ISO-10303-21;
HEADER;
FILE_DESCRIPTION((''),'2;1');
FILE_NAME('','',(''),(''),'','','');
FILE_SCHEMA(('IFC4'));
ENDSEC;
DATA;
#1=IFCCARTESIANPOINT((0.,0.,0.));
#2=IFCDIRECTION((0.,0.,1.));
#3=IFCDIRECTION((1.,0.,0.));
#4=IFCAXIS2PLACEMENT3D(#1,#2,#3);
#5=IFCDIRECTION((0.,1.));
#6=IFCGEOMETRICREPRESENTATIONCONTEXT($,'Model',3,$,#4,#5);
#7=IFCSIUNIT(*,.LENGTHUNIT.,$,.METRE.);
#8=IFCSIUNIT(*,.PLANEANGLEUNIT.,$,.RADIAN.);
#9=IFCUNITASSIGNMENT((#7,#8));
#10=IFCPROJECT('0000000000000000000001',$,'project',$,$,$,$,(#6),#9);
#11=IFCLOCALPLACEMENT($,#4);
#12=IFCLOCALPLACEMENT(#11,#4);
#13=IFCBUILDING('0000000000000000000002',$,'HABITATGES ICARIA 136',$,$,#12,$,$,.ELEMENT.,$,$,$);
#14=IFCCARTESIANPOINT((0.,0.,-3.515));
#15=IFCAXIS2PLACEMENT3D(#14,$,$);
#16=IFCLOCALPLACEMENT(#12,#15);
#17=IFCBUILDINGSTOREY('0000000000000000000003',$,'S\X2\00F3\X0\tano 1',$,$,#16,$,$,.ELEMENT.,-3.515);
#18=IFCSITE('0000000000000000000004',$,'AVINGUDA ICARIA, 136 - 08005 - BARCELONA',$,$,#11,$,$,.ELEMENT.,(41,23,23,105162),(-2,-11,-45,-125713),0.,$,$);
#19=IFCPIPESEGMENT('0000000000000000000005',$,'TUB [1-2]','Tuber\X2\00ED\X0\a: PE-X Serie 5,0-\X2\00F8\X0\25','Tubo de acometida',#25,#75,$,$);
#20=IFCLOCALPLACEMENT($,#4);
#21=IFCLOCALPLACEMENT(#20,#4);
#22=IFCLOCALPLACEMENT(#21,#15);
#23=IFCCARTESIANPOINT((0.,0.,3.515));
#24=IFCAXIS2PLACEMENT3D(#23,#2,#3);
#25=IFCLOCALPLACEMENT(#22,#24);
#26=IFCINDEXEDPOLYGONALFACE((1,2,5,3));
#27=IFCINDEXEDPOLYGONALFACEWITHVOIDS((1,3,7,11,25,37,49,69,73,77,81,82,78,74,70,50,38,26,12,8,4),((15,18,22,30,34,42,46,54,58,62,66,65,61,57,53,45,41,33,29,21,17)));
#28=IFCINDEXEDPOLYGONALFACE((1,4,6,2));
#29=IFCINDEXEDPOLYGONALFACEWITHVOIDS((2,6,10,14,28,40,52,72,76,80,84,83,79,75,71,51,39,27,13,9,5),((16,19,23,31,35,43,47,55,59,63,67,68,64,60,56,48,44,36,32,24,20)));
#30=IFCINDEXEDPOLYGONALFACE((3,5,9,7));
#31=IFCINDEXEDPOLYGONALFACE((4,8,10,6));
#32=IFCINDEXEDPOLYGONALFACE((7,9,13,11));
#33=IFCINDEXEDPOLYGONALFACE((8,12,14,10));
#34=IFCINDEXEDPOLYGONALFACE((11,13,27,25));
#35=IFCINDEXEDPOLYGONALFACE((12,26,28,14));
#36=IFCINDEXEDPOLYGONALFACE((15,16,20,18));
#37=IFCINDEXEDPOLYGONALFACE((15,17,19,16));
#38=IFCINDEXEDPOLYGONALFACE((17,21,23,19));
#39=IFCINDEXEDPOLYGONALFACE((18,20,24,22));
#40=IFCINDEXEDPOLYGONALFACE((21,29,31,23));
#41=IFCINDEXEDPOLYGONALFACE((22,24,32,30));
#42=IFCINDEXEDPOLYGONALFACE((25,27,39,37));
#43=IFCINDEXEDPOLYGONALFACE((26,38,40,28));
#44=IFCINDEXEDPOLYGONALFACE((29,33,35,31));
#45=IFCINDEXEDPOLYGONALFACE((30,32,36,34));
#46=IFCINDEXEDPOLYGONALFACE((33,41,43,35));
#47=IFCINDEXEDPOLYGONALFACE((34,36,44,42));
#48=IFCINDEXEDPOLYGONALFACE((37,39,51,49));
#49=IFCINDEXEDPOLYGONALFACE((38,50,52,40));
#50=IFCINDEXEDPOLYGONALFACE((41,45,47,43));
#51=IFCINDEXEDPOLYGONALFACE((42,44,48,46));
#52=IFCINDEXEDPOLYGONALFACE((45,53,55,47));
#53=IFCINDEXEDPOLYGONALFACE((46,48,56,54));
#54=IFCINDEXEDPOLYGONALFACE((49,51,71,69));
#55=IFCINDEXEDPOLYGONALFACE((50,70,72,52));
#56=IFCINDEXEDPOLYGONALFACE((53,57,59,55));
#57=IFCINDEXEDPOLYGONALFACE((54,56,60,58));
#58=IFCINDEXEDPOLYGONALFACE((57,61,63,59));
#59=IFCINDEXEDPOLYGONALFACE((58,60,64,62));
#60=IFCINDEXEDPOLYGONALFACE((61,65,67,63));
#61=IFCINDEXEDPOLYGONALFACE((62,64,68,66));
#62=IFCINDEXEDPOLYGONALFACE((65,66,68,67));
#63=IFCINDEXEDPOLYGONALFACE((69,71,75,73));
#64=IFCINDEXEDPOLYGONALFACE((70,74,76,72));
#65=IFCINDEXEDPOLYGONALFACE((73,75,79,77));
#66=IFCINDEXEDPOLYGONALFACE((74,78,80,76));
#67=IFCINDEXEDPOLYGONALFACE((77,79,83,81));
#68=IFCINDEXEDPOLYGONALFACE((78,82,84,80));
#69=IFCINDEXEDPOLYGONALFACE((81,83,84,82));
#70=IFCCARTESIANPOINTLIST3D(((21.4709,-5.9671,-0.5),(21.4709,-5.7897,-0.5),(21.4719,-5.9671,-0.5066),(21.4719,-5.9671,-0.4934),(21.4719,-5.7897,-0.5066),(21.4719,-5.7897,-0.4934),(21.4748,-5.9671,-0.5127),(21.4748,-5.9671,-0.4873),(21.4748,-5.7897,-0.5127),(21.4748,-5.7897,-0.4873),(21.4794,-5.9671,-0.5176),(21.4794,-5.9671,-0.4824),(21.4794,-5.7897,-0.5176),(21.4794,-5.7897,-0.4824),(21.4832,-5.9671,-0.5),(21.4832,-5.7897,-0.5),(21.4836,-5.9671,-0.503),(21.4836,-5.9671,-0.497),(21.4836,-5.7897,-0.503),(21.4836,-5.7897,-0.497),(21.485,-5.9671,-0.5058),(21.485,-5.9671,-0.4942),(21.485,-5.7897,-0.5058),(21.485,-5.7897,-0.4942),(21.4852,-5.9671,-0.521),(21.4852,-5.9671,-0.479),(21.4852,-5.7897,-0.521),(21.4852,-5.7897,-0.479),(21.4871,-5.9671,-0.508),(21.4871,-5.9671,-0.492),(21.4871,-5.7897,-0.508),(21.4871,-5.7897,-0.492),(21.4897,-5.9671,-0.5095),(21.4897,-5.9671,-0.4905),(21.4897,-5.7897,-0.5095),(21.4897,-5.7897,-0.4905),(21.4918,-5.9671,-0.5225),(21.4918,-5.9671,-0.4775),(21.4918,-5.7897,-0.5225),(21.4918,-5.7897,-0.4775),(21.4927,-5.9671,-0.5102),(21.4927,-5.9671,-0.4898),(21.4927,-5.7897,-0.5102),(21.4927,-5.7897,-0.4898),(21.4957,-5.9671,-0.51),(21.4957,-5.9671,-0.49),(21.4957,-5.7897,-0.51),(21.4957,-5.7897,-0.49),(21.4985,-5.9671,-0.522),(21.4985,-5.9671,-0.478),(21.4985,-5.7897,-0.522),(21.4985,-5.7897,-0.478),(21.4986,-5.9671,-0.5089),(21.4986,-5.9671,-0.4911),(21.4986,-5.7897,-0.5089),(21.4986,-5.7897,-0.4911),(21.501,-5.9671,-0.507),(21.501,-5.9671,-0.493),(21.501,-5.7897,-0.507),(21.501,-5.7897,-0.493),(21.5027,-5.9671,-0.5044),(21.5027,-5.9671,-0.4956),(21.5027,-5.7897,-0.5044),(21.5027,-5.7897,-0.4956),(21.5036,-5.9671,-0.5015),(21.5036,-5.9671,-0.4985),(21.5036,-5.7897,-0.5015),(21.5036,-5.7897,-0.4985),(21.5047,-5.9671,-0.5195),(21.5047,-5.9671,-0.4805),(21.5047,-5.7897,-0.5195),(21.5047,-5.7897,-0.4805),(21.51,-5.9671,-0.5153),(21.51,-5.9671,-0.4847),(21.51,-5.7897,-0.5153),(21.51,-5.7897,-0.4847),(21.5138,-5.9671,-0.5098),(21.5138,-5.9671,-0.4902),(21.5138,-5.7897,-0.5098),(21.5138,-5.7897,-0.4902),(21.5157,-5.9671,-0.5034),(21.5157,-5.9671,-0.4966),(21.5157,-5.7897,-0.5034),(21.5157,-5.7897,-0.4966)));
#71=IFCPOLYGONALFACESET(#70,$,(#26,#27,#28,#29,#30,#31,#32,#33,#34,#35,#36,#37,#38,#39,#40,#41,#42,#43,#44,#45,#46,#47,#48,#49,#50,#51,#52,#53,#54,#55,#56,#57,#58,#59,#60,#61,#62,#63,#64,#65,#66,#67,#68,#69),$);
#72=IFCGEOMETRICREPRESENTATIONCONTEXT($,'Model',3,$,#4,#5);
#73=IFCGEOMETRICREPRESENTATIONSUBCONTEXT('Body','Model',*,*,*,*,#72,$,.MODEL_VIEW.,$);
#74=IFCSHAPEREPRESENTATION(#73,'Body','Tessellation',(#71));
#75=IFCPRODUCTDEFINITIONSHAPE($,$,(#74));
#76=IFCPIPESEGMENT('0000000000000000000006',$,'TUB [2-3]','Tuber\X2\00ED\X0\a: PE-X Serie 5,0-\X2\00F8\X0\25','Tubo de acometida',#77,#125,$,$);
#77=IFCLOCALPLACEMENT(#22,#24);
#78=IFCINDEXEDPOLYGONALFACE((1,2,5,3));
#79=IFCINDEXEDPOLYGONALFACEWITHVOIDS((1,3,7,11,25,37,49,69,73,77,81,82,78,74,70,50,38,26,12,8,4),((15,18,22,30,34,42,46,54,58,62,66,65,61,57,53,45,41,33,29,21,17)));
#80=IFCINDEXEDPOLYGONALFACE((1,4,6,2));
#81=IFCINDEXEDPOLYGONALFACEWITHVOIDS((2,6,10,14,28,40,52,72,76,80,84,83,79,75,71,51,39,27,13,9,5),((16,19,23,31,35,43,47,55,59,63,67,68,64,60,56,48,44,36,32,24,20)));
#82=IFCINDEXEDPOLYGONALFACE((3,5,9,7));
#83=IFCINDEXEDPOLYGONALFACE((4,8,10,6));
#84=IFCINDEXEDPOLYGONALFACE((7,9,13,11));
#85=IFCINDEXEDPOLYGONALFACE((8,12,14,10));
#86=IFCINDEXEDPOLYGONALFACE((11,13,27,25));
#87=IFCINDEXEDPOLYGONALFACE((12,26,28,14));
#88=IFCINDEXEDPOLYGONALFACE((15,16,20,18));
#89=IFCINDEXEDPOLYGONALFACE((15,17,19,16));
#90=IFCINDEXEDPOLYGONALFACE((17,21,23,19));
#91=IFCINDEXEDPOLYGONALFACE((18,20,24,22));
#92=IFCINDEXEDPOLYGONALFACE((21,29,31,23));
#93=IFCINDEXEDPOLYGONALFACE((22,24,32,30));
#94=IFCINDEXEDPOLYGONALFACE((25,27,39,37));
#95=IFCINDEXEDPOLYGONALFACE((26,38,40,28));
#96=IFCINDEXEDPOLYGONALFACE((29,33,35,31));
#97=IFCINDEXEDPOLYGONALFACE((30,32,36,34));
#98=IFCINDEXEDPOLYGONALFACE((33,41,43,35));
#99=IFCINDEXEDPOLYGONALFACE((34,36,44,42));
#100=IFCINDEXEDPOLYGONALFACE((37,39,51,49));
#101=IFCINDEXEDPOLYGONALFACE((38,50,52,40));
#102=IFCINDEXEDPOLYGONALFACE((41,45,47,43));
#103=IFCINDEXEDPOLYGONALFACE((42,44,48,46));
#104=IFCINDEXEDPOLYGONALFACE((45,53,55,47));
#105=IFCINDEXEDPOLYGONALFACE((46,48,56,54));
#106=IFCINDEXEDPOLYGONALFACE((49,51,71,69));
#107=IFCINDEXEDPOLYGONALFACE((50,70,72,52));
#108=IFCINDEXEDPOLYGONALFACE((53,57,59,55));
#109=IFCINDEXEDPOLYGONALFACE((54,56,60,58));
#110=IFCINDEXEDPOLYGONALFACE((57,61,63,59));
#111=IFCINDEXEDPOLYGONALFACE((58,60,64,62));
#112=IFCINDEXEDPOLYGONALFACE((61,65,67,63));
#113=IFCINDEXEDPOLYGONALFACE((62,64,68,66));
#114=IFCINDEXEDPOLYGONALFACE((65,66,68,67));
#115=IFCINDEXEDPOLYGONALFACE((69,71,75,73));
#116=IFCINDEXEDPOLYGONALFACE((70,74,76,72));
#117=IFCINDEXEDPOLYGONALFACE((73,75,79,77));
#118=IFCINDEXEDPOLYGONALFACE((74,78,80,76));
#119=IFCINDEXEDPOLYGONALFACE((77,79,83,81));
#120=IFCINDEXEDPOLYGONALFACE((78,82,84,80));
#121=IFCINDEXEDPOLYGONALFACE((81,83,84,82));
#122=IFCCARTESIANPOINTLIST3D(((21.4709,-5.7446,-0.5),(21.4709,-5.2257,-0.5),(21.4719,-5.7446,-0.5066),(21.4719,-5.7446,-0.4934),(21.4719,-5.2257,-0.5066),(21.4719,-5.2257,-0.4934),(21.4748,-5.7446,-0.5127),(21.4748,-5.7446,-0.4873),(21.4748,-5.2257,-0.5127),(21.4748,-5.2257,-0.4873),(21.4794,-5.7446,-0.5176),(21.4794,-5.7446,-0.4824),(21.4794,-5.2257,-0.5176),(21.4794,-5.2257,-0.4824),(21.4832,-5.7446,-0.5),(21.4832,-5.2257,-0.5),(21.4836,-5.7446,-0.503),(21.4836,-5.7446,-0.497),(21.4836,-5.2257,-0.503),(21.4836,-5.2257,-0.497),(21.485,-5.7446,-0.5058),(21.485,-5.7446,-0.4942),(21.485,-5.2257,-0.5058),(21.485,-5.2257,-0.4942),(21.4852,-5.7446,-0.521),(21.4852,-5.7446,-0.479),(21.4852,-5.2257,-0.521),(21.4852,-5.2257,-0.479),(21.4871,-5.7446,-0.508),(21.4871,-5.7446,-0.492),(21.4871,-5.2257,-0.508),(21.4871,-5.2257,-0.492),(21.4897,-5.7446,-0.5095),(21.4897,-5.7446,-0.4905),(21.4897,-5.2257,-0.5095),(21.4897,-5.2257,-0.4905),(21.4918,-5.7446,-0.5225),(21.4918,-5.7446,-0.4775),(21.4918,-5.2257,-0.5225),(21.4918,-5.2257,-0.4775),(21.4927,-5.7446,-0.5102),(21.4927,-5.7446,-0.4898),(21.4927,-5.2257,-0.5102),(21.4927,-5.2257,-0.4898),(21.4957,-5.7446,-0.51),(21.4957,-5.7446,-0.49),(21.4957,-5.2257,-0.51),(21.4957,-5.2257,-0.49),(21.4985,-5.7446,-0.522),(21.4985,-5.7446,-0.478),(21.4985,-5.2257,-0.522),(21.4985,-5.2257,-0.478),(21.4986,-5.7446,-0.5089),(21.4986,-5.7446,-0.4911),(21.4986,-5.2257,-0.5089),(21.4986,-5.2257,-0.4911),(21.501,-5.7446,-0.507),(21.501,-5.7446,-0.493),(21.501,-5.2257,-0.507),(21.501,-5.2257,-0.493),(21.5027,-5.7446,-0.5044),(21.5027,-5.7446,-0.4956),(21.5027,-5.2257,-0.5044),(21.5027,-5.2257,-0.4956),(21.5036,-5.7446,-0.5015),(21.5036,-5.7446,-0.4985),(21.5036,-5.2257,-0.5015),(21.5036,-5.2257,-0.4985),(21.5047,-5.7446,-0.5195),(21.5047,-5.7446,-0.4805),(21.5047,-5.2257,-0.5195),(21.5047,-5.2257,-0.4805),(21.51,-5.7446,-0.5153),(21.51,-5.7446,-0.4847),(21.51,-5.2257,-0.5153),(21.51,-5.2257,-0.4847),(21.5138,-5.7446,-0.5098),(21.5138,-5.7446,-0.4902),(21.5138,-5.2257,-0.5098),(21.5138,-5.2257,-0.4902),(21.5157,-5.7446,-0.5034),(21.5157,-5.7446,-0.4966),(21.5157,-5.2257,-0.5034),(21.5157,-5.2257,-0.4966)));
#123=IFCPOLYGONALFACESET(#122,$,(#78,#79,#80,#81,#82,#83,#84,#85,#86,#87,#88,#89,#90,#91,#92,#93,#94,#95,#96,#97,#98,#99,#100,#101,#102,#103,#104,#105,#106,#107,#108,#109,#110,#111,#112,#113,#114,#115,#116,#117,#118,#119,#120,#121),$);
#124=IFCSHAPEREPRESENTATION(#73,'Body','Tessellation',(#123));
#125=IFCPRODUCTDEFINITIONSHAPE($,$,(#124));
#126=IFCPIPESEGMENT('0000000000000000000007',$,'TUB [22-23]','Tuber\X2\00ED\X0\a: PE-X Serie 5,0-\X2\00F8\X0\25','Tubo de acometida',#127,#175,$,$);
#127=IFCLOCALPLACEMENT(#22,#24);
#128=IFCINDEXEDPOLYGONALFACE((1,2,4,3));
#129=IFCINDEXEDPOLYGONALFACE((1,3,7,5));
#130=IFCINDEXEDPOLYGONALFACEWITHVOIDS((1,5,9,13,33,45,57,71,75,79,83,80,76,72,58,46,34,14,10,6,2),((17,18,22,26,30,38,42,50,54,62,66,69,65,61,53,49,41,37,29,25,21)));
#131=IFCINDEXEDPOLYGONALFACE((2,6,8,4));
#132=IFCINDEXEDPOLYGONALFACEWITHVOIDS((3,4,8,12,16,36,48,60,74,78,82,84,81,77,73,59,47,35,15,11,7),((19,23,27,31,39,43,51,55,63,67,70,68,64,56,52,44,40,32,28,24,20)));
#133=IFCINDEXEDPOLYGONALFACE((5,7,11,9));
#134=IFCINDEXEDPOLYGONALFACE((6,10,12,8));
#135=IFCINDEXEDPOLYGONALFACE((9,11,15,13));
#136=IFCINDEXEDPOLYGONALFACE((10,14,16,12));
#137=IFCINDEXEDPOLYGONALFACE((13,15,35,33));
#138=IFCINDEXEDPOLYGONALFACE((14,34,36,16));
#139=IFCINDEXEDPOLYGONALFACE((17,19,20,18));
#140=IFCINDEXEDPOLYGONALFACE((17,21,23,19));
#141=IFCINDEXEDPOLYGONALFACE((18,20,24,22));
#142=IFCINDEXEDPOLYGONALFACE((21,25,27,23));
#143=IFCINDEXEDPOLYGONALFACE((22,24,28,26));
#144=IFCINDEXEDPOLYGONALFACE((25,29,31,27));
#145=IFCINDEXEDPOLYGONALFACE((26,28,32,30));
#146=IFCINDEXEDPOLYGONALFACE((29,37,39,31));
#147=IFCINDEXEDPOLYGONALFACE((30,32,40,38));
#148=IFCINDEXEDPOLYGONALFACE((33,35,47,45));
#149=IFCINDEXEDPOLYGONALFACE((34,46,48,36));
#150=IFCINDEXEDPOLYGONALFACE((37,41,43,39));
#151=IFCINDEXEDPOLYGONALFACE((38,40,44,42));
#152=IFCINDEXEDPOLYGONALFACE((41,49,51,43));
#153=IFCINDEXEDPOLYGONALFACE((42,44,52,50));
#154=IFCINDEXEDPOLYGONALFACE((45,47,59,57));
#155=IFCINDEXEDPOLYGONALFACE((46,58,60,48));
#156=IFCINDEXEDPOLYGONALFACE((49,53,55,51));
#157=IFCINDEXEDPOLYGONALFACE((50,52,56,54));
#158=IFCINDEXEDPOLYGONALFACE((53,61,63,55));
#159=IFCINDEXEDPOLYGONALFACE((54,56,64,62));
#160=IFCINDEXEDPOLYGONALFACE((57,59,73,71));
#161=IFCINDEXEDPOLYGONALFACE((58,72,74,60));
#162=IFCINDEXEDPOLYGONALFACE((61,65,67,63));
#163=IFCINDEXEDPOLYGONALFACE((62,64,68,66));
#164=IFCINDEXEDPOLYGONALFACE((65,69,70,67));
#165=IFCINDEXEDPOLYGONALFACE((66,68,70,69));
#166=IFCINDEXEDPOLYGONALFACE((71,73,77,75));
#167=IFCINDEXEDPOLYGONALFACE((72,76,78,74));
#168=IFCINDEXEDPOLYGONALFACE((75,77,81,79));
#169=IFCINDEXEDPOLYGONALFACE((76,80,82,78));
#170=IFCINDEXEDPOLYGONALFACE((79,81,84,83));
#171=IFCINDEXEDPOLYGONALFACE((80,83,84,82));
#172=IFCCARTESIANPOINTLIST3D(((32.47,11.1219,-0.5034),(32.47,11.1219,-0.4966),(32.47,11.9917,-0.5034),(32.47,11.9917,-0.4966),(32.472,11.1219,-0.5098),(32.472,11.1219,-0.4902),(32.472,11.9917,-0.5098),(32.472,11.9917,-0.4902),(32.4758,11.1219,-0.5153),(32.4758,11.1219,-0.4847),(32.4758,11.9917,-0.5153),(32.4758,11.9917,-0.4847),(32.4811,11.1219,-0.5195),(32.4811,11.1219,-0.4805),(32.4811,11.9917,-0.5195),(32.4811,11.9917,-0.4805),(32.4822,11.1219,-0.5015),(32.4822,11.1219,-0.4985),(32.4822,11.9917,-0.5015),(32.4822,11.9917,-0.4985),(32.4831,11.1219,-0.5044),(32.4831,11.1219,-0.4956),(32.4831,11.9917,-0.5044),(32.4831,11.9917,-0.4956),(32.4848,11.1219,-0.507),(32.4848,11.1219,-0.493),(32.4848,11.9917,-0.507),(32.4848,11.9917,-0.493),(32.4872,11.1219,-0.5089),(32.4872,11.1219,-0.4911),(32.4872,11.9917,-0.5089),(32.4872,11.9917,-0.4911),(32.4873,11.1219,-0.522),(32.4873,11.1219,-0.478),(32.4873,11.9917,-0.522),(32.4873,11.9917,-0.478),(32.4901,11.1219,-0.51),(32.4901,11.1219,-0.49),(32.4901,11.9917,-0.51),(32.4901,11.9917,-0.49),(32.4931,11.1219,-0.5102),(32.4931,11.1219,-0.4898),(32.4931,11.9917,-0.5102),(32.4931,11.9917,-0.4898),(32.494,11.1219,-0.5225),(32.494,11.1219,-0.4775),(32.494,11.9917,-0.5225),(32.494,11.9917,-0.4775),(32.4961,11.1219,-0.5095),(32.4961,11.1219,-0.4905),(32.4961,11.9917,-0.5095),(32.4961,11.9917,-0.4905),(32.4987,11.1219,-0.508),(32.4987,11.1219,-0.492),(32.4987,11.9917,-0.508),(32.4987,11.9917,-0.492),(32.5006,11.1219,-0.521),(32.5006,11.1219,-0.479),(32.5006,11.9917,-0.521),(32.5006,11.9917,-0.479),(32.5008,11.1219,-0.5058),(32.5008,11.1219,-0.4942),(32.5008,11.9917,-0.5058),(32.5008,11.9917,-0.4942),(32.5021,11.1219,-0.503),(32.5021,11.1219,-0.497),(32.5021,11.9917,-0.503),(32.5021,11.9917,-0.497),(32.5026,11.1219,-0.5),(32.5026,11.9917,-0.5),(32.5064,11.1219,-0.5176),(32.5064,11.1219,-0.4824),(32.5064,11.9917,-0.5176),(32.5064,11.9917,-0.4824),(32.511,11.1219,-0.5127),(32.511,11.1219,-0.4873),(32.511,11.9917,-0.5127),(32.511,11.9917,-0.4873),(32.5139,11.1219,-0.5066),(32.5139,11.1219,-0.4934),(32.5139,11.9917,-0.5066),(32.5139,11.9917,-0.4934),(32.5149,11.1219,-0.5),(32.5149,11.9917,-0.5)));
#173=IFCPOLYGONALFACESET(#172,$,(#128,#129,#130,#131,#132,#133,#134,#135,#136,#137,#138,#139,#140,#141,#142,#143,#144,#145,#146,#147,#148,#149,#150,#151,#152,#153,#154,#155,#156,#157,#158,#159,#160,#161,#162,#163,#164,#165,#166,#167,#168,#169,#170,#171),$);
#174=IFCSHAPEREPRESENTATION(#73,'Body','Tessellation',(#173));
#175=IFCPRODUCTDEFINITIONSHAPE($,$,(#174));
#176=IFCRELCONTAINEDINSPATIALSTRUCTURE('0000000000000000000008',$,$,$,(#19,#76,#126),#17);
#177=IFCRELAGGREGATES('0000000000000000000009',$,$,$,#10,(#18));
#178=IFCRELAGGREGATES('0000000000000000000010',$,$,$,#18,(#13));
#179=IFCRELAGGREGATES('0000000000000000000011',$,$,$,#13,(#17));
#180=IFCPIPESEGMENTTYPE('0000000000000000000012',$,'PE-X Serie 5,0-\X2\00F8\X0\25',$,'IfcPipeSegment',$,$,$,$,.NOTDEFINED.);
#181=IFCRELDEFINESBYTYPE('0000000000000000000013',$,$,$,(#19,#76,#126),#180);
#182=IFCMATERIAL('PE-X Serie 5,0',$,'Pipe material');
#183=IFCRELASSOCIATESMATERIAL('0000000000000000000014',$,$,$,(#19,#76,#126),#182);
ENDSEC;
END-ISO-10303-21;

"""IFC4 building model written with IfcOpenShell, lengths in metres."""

from ifc_helpers import new_model, si_unit, direction, frame, origin_with_axes, origin_2d_with_axis, place, context, subcontext, project, spatial, hollow_circle, extrude, material, type_object, element, save


model = new_model("IFC4")

# Units and contexts
model_context_1 = context("Model", 3, world=origin_with_axes(), true_north=direction((0.0, 1.0)))
model_context_2 = context("Model", 3, world=origin_with_axes(), true_north=direction((0.0, 1.0)))
body_context_1 = subcontext(model_context_2, "Body", "Model", "MODEL_VIEW")
ifc_project = project(units=[si_unit("LENGTHUNIT", "METRE"), si_unit("PLANEANGLEUNIT", "RADIAN")], contexts=[model_context_1])

# Site, building, storey
site_placement = place(None, origin_with_axes())
site = spatial("IfcSite", under=ifc_project, at=site_placement, Name="AVINGUDA ICARIA, 136 - 08005 - BARCELONA", CompositionType="ELEMENT", RefLatitude=(41, 23, 23, 105162), RefLongitude=(-2, -11, -45, -125713), RefElevation=0.0)
building_placement = place(site_placement, origin_with_axes())
building = spatial("IfcBuilding", under=site, at=building_placement, Name="HABITATGES ICARIA 136", CompositionType="ELEMENT")
storey_placement = place(building_placement, frame((0.0, 0.0, -3.515)))
storey = spatial("IfcBuildingStorey", under=building, at=storey_placement, Name="Sótano 1", CompositionType="ELEMENT", Elevation=-3.515)

# Pipe segments
ifc_material_1 = material(Name="PE-X Serie 5,0", Category="Pipe material")
pipe_segment_type = type_object("IfcPipeSegmentType", Name="PE-X Serie 5,0-ø25", ApplicableOccurrence="IfcPipeSegment", PredefinedType="NOTDEFINED")
placement_1 = place(None, origin_with_axes())
placement_2 = place(placement_1, origin_with_axes())
placement_3 = place(placement_2, frame((0.0, 0.0, -3.515)))
pipe_segment_1_placement = place(placement_3, frame((0.0, 0.0, 3.515), z_axis=(0.0, 0.0, 1.0), x_axis=(1.0, 0.0, 0.0)))
element("IfcPipeSegment", 1, at=pipe_segment_1_placement, inside=storey, type_object=pipe_segment_type, material=ifc_material_1, Name="TUB [1-2]", Description="Tubería: PE-X Serie 5,0-ø25", ObjectType="Tubo de acometida", context=body_context_1, shape_type="SweptSolid", body=[
    extrude(hollow_circle(Radius=0.0226, WallThickness=0.0123, at=origin_2d_with_axis()), frame((21.4934, -5.9671, -0.5), z_axis=(0.0, 1.0, 0.0), x_axis=(-1.0, 0.0, 0.0)), (0.0, 0.0, 1.0), 0.1774),
])
pipe_segment_2_placement = place(placement_3, frame((0.0, 0.0, 3.515), z_axis=(0.0, 0.0, 1.0), x_axis=(1.0, 0.0, 0.0)))
element("IfcPipeSegment", 2, at=pipe_segment_2_placement, inside=storey, type_object=pipe_segment_type, material=ifc_material_1, Name="TUB [2-3]", Description="Tubería: PE-X Serie 5,0-ø25", ObjectType="Tubo de acometida", context=body_context_1, shape_type="SweptSolid", body=[
    extrude(hollow_circle(Radius=0.0226, WallThickness=0.0123, at=origin_2d_with_axis()), frame((21.4934, -5.7446, -0.5), z_axis=(0.0, 1.0, 0.0), x_axis=(-1.0, 0.0, 0.0)), (0.0, 0.0, 1.0), 0.5188),
])
pipe_segment_3_placement = place(placement_3, frame((0.0, 0.0, 3.515), z_axis=(0.0, 0.0, 1.0), x_axis=(1.0, 0.0, 0.0)))
element("IfcPipeSegment", 3, at=pipe_segment_3_placement, inside=storey, type_object=pipe_segment_type, material=ifc_material_1, Name="TUB [22-23]", Description="Tubería: PE-X Serie 5,0-ø25", ObjectType="Tubo de acometida", context=body_context_1, shape_type="SweptSolid", body=[
    extrude(hollow_circle(Radius=0.0226, WallThickness=0.0123, at=origin_2d_with_axis()), frame((32.4923, 11.9917, -0.5), z_axis=(0.0, -1.0, 0.0), x_axis=(1.0, 0.0, 0.0)), (0.0, 0.0, 1.0), 0.8698),
])

save(model, "model.ifc")
